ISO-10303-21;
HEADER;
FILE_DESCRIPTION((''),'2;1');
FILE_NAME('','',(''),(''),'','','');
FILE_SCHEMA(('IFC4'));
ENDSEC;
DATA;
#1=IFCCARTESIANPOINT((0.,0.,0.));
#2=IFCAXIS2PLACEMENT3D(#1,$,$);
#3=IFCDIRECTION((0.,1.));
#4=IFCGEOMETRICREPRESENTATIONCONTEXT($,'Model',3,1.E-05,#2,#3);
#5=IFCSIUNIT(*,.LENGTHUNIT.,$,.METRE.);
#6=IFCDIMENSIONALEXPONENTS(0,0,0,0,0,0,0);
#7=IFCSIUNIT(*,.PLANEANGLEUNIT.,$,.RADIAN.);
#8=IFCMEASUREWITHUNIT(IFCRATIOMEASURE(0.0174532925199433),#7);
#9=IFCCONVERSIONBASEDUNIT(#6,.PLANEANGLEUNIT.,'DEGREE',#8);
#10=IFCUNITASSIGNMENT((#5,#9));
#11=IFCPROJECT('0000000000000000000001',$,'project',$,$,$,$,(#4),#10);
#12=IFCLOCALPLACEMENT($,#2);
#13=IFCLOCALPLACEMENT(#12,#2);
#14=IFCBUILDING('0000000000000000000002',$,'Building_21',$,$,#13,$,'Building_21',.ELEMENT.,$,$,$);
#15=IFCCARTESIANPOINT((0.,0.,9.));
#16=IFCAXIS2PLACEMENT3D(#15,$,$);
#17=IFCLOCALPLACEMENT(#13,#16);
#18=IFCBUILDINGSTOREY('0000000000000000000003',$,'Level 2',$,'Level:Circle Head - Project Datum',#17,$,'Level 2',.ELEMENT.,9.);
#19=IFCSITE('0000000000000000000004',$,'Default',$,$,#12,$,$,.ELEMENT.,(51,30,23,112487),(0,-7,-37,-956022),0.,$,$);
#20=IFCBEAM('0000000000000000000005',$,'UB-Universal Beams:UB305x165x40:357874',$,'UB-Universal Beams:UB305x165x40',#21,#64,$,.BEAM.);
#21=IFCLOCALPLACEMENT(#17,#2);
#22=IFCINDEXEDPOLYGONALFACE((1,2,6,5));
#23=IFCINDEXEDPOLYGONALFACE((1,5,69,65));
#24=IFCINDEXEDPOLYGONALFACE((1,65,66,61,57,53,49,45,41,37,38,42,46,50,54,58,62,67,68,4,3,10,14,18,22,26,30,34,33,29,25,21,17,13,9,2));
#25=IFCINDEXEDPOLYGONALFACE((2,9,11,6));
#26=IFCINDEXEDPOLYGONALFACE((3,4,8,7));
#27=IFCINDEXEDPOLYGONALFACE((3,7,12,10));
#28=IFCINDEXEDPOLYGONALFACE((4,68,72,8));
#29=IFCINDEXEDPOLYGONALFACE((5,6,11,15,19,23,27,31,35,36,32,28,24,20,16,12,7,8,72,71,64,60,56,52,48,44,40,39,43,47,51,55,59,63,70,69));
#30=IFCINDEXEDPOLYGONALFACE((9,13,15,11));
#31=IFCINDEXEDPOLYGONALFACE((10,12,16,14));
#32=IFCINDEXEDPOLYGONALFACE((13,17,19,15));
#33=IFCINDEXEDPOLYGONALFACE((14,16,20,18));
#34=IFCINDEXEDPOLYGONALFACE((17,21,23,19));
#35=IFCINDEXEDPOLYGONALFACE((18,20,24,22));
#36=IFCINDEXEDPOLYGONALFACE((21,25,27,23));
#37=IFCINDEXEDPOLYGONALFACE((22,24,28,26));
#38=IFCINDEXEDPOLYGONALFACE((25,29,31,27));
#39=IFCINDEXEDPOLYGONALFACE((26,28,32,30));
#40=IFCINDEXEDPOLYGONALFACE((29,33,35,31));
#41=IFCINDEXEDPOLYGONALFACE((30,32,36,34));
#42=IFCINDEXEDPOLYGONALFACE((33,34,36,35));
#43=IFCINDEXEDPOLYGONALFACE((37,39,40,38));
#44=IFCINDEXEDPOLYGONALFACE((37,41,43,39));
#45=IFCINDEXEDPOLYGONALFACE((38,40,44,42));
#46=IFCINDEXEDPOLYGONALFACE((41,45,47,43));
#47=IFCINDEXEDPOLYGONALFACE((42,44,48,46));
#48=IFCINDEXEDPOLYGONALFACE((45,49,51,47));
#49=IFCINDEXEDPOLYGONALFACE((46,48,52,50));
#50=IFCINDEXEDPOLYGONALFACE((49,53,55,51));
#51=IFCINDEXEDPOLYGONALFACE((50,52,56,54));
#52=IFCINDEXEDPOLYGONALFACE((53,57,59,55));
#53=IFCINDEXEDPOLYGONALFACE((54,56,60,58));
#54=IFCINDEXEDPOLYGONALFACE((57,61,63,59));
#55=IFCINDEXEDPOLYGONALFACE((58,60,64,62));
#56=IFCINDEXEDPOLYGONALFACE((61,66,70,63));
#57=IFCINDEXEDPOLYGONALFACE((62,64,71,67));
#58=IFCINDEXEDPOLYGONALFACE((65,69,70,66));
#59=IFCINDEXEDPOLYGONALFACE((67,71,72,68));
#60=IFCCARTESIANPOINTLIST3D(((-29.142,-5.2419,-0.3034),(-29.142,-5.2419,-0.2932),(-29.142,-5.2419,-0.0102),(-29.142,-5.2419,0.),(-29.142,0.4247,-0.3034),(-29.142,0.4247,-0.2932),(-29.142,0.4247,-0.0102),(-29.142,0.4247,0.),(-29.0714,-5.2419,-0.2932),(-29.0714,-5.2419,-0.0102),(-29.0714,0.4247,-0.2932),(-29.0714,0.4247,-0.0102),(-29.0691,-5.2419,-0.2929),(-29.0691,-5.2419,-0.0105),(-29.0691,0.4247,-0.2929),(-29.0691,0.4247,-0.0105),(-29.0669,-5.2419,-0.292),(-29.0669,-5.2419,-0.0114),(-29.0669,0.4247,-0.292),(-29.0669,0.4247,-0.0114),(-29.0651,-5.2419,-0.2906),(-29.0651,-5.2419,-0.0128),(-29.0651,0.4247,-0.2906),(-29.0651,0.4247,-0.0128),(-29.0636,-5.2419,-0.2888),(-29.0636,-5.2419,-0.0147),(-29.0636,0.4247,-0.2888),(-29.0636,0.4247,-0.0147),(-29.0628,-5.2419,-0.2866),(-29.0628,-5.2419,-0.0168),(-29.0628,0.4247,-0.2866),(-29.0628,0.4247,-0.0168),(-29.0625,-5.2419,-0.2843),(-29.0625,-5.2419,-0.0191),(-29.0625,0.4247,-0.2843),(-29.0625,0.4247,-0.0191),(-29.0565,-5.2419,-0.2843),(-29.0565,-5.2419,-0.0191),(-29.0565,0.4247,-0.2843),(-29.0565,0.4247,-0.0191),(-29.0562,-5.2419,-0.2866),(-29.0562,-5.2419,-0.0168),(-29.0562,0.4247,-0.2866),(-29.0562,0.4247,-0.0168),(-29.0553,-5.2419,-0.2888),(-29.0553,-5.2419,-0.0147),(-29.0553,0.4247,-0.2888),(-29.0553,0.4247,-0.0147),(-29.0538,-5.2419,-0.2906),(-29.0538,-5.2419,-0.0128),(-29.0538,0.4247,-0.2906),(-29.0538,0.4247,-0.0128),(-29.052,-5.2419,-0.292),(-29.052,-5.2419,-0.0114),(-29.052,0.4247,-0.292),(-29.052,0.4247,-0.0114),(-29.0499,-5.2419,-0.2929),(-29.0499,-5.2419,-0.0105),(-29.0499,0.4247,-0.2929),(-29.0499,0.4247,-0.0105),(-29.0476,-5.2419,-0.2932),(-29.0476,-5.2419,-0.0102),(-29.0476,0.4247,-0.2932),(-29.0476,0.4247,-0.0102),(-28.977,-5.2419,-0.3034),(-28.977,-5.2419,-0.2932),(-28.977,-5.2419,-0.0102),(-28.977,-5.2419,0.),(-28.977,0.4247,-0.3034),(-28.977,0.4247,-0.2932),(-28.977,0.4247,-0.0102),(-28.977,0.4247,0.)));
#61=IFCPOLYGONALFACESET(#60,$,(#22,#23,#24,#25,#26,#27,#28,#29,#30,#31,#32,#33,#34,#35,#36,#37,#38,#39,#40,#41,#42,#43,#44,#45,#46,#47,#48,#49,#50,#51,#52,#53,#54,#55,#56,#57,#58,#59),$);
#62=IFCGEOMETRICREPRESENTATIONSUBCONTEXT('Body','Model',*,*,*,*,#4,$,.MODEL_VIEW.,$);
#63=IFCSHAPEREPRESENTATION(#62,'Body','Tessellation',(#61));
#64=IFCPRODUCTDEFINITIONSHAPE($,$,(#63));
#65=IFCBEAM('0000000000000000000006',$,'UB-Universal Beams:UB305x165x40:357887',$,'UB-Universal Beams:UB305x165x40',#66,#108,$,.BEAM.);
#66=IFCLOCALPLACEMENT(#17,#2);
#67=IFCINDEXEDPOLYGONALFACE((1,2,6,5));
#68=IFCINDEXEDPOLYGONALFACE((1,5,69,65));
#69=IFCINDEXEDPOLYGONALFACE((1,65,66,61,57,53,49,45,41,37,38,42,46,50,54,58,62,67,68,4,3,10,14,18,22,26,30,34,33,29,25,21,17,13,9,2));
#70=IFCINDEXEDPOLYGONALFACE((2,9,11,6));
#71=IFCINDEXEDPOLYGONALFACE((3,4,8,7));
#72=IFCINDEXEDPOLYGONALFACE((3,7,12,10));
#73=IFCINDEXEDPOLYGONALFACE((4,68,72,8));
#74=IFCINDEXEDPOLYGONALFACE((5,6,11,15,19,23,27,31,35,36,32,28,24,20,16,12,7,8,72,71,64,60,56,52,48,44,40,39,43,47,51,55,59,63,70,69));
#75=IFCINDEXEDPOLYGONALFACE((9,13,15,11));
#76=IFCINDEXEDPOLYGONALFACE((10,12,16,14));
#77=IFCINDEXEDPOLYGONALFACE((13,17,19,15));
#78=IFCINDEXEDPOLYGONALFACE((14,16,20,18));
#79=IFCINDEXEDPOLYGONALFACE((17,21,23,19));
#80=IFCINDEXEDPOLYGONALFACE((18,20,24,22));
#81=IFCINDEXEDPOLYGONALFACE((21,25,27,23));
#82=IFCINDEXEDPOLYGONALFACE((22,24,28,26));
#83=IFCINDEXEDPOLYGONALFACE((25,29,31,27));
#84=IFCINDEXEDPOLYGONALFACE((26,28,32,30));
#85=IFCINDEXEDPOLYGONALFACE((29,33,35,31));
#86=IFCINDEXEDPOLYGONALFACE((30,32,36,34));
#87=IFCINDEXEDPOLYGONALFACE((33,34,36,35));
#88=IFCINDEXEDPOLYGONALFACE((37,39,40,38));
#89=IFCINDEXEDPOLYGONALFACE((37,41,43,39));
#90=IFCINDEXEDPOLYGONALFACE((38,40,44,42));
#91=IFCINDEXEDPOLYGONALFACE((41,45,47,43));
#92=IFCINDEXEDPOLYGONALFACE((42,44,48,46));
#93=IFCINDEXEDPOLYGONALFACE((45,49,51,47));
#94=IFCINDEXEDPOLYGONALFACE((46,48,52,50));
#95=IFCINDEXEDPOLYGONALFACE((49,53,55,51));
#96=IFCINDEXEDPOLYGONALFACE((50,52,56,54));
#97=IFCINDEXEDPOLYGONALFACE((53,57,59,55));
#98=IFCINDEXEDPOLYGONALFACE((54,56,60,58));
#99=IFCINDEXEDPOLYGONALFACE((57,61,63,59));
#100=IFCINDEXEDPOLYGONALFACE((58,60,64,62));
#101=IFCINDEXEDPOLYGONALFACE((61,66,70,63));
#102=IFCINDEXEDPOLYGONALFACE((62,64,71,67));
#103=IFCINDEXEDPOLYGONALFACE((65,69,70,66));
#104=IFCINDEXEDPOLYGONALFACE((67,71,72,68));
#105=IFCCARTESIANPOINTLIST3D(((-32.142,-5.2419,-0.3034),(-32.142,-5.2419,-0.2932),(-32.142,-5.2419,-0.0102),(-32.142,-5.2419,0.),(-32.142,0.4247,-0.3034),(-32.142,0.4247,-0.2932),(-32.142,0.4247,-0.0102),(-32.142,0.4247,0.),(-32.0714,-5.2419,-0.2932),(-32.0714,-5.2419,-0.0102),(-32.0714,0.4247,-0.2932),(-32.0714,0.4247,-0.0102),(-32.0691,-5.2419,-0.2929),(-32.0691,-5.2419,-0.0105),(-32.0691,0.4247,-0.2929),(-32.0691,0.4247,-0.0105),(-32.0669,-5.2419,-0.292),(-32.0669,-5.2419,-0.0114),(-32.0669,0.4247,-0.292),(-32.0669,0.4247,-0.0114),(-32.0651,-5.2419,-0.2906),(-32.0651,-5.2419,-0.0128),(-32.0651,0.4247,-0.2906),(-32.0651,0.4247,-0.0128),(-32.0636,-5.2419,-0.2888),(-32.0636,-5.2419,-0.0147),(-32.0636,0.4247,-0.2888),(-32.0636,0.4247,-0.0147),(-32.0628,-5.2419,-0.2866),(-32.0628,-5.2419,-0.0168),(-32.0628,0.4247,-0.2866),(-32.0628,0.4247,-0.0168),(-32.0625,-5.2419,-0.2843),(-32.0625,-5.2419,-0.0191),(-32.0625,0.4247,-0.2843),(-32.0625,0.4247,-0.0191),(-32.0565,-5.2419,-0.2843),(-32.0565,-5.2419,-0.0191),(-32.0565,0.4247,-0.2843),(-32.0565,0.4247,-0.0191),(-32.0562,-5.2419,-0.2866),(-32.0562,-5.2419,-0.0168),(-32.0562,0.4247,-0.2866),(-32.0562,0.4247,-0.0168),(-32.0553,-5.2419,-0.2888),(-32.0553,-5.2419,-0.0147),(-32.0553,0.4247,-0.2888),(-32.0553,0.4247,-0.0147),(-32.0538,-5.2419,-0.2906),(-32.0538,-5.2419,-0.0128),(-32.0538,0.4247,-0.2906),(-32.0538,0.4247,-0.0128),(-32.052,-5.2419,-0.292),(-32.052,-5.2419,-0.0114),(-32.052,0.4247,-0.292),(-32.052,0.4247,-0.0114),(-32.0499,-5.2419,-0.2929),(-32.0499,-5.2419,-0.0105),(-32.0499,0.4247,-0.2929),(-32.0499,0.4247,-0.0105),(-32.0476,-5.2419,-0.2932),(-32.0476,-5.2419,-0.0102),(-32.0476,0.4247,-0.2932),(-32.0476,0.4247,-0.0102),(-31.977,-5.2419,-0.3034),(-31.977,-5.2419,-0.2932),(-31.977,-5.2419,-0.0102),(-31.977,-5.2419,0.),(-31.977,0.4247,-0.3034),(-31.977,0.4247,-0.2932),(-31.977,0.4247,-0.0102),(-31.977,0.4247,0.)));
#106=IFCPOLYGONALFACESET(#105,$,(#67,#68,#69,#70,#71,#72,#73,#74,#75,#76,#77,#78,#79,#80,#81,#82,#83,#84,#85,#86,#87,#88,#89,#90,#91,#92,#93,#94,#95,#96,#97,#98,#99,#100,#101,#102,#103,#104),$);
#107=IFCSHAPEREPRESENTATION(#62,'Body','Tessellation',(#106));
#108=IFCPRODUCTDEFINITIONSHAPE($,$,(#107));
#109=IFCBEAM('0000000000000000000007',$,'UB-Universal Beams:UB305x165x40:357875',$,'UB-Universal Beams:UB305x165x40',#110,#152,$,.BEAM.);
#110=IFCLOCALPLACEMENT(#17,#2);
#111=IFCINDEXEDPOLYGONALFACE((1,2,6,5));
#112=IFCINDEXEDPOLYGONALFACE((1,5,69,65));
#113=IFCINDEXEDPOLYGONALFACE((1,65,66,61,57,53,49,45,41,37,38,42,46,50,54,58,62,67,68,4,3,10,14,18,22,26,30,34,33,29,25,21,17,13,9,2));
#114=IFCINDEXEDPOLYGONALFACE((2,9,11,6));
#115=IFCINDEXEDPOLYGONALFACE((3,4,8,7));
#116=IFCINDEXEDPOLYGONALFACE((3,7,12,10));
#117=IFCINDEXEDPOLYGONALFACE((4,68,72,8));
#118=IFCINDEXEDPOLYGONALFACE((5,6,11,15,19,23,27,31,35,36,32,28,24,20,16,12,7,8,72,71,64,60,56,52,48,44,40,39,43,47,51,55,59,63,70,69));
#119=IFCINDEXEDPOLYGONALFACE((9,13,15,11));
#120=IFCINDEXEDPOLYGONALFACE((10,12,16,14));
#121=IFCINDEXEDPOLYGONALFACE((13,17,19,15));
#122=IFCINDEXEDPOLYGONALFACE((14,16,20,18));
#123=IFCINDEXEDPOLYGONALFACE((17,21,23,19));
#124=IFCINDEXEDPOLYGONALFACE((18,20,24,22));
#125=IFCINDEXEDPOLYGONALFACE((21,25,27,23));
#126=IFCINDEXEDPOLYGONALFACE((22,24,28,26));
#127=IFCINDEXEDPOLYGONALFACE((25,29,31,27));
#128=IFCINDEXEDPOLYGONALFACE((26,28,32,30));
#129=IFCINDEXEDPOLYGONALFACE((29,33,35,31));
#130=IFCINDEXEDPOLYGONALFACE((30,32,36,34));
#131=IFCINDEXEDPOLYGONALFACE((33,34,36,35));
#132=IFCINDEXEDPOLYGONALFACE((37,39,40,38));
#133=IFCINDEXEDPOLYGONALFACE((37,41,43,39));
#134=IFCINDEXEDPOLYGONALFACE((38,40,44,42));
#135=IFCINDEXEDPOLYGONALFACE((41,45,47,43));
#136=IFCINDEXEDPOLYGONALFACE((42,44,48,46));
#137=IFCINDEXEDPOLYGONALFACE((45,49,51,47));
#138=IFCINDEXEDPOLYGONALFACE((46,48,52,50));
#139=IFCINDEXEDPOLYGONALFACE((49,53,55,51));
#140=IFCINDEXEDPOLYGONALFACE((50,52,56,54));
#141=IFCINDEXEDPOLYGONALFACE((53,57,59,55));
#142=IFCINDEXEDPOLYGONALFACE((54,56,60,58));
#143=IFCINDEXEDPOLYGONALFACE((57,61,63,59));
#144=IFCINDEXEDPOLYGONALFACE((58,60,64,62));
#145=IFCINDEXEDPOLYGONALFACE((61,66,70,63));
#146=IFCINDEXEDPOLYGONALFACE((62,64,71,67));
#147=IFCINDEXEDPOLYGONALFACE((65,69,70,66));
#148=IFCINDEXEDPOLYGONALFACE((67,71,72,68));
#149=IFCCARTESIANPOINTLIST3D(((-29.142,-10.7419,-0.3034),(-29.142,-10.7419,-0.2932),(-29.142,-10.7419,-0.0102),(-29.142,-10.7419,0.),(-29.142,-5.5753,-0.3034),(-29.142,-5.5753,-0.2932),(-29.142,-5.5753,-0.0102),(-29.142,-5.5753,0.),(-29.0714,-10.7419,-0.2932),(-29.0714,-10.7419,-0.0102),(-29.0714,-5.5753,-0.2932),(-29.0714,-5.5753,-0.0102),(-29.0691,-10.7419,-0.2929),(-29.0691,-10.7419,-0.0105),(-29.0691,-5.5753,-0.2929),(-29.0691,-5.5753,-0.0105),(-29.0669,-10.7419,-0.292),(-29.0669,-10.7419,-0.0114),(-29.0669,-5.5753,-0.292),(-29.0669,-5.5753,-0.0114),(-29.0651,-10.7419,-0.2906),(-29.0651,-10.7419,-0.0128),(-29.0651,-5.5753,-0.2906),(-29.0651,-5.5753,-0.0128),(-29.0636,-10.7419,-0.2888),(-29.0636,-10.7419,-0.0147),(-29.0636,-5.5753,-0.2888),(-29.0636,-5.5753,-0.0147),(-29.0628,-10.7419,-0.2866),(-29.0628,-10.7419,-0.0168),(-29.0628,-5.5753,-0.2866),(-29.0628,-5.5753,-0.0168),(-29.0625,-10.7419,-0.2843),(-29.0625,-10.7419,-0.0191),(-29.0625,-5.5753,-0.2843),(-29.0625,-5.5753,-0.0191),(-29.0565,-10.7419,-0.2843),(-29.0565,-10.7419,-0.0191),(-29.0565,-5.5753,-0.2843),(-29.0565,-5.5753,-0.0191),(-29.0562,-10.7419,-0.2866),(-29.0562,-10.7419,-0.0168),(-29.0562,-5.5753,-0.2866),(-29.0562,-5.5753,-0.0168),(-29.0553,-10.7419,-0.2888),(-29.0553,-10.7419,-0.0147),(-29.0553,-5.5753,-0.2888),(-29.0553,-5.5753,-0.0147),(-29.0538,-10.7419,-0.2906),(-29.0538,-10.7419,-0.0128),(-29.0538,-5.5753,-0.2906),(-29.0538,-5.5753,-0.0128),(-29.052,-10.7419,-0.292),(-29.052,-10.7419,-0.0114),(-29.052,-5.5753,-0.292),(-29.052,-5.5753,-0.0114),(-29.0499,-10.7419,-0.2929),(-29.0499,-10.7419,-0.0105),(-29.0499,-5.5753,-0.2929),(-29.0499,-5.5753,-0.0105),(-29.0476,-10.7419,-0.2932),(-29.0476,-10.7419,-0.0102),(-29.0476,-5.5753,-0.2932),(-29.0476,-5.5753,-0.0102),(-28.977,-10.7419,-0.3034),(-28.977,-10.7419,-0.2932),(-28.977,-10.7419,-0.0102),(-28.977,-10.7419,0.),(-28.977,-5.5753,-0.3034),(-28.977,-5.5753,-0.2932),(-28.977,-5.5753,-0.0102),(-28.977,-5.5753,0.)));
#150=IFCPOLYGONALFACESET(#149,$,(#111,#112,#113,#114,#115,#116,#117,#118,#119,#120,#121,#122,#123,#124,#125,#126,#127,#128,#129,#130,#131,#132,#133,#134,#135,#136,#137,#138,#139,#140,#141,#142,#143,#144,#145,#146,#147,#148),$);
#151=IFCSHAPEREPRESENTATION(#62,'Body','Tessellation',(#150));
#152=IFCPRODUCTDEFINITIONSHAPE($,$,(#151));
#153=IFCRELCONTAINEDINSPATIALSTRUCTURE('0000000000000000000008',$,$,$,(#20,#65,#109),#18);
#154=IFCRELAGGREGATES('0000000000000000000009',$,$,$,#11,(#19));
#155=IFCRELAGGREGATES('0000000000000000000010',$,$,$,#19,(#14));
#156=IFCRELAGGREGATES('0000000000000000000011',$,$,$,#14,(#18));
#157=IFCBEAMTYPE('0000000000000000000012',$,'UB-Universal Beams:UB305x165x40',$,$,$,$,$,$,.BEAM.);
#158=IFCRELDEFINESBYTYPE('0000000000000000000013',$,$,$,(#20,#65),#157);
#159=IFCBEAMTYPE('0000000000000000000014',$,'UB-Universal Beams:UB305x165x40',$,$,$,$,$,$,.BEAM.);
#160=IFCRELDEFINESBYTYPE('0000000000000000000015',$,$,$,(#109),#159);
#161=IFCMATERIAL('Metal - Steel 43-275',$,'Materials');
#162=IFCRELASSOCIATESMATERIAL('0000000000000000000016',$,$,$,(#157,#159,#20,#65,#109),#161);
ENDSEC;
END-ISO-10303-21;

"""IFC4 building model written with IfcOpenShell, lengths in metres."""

from ifc_helpers import new_model, entity, si_unit, converted_unit, direction, frame, frame_2d, origin, place, context, subcontext, project, spatial, polyline, circle_curve, parameter, trimmed, segment, composite_curve, i_section, outline, extrude, source, transform, mapped, material, material_profile, profile_set, profile_usage, type_object, type_shapes, element, save


model = new_model("IFC4")

# Units and contexts
model_context = context("Model", 3, precision=1e-05, world=origin(), true_north=direction((0.0, 1.0)))
body_context = subcontext(model_context, "Body", "Model", "MODEL_VIEW")
ifc_project = project(units=[si_unit("LENGTHUNIT", "METRE"), converted_unit("PLANEANGLEUNIT", "DEGREE", entity("IfcRatioMeasure", 0.0174532925199433), si_unit("PLANEANGLEUNIT", "RADIAN"), dimensions=[0, 0, 0, 0, 0, 0, 0])], contexts=[model_context])

# Site, building, storey
site_placement = place(None, origin())
site = spatial("IfcSite", under=ifc_project, at=site_placement, Name="Default", CompositionType="ELEMENT", RefLatitude=(51, 30, 23, 112487), RefLongitude=(0, -7, -37, -956022), RefElevation=0.0)
building_placement = place(site_placement, origin())
building = spatial("IfcBuilding", under=site, at=building_placement, Name="Building_21", LongName="Building_21", CompositionType="ELEMENT")
storey_placement = place(building_placement, frame((0.0, 0.0, 9.0)))
storey = spatial("IfcBuildingStorey", under=building, at=storey_placement, Name="Level 2", ObjectType="Level:Circle Head - Project Datum", LongName="Level 2", CompositionType="ELEMENT", Elevation=9.0)

# Shared definitions
ifc_material_1 = material(Name="Metal - Steel 43-275", Category="Materials")

# Beams
ifc_material_profile_1 = material_profile(ifc_material_1, outline(composite_curve([segment(polyline([(0.0119, -0.1415, 0.0), (0.0825, -0.1415, 0.0)]), True, "CONTINUOUS"), segment(polyline([(0.0825, -0.1415, 0.0), (0.0825, -0.1517, 0.0)]), True, "CONTINUOUS"), segment(polyline([(0.0825, -0.1517, 0.0), (-0.0825, -0.1517, 0.0)]), True, "CONTINUOUS"), segment(polyline([(-0.0825, -0.1517, 0.0), (-0.0825, -0.1415, 0.0)]), True, "CONTINUOUS"), segment(polyline([(-0.0825, -0.1415, 0.0), (-0.0119, -0.1415, 0.0)]), True, "CONTINUOUS"), segment(trimmed(circle_curve(frame((-0.0119, -0.1326, 0.0), z_axis=(0.0, 0.0, 1.0), x_axis=(-1.0, 0.0, 0.0)), 0.0089), [parameter(90.0)], [parameter(180.0)], True, "PARAMETER"), True, "CONTINUOUS"), segment(polyline([(-0.003, -0.1326, 0.0), (-0.003, 0.1326, 0.0)]), True, "CONTINUOUS"), segment(trimmed(circle_curve(frame((-0.0119, 0.1326, 0.0), z_axis=(0.0, 0.0, 1.0), x_axis=(-1.0, 0.0, 0.0)), 0.0089), [parameter(180.0)], [parameter(270.0)], True, "PARAMETER"), True, "CONTINUOUS"), segment(polyline([(-0.0119, 0.1415, 0.0), (-0.0825, 0.1415, 0.0)]), True, "CONTINUOUS"), segment(polyline([(-0.0825, 0.1415, 0.0), (-0.0825, 0.1517, 0.0)]), True, "CONTINUOUS"), segment(polyline([(-0.0825, 0.1517, 0.0), (0.0825, 0.1517, 0.0)]), True, "CONTINUOUS"), segment(polyline([(0.0825, 0.1517, 0.0), (0.0825, 0.1415, 0.0)]), True, "CONTINUOUS"), segment(polyline([(0.0825, 0.1415, 0.0), (0.0119, 0.1415, 0.0)]), True, "CONTINUOUS"), segment(trimmed(circle_curve(frame((0.0119, 0.1326, 0.0), z_axis=(0.0, 0.0, 1.0), x_axis=(-1.0, 0.0, 0.0)), 0.0089), [parameter(270.0)], [parameter(0.0)], True, "PARAMETER"), True, "CONTINUOUS"), segment(polyline([(0.003, 0.1326, 0.0), (0.003, -0.1326, 0.0)]), True, "CONTINUOUS"), segment(trimmed(circle_curve(frame((0.0119, -0.1326, 0.0), z_axis=(0.0, 0.0, 1.0), x_axis=(-1.0, 0.0, 0.0)), 0.0089), [parameter(0.0)], [parameter(90.0)], True, "PARAMETER"), True, "CONTINUOUS")], self_intersect=False), kind="CURVE"), Name="UB305x165x40")
ifc_material_profile_2 = material_profile(ifc_material_1, outline(composite_curve([segment(polyline([(-1.3346, 0.0825, -0.1415), (-1.3346, 0.0825, -0.1517)]), True, "CONTINUOUS"), segment(polyline([(-1.3346, 0.0825, -0.1517), (-1.3346, -0.0825, -0.1517)]), True, "CONTINUOUS"), segment(polyline([(-1.3346, -0.0825, -0.1517), (-1.3346, -0.0825, -0.1415)]), True, "CONTINUOUS"), segment(polyline([(-1.3346, -0.0825, -0.1415), (-1.3346, -0.003, -0.1415)]), True, "CONTINUOUS"), segment(polyline([(-1.3346, -0.003, -0.1415), (-1.3346, -0.003, 0.1415)]), True, "CONTINUOUS"), segment(polyline([(-1.3346, -0.003, 0.1415), (-1.3346, -0.0825, 0.1415)]), True, "CONTINUOUS"), segment(polyline([(-1.3346, -0.0825, 0.1415), (-1.3346, -0.0825, 0.1517)]), True, "CONTINUOUS"), segment(polyline([(-1.3346, -0.0825, 0.1517), (-1.3346, 0.0825, 0.1517)]), True, "CONTINUOUS"), segment(polyline([(-1.3346, 0.0825, 0.1517), (-1.3346, 0.0825, 0.1415)]), True, "CONTINUOUS"), segment(polyline([(-1.3346, 0.0825, 0.1415), (-1.3346, 0.003, 0.1415)]), True, "CONTINUOUS"), segment(polyline([(-1.3346, 0.003, 0.1415), (-1.3346, 0.003, -0.1415)]), True, "CONTINUOUS"), segment(polyline([(-1.3346, 0.003, -0.1415), (-1.3346, 0.0825, -0.1415)]), True, "CONTINUOUS")], self_intersect=False), kind="CURVE"), Name="UB305x165x40")
ifc_profile_set_1 = profile_set([ifc_material_profile_1, ifc_material_profile_2], Name="UB305x165x40")
ifc_profile_usage_1 = profile_usage(ifc_profile_set_1, cardinal=8)
beam_type_1 = type_object("IfcBeamType", Name="UB-Universal Beams:UB305x165x40", PredefinedType="BEAM", material=ifc_profile_set_1)
shared_shape_1 = source(origin(), body_context, "Body", "SweptSolid", [
    extrude(i_section(OverallWidth=0.165, OverallDepth=0.3034, WebThickness=0.006, FlangeThickness=0.0102, FilletRadius=0.0089, at=frame_2d((0.0, 0.0), x_axis=(0.0, 1.0))), frame((-2.8333, 0.0, 0.0), z_axis=(1.0, 0.0, 0.0), x_axis=(0.0, 0.0, -1.0)), (0.0, 0.0, 1.0), 5.6666),
])
type_shapes(beam_type_1, [shared_shape_1])
beam_1_placement = place(storey_placement, frame((-29.0595, -2.4086, -0.1517), z_axis=(0.0, 0.0, 1.0), x_axis=(0.0, 1.0, 0.0)))
element("IfcBeam", 1, at=beam_1_placement, inside=storey, type_object=beam_type_1, material=ifc_profile_usage_1, Name="UB-Universal Beams:UB305x165x40:357874", ObjectType="UB-Universal Beams:UB305x165x40", PredefinedType="BEAM", context=body_context, shape_type="MappedRepresentation", body=[
    mapped(shared_shape_1, transform((0.0, 0.0, 0.0), scale=1.0)),
])
ifc_profile_usage_2 = profile_usage(ifc_profile_set_1, cardinal=8)
beam_2_placement = place(storey_placement, frame((-32.0595, -2.4086, -0.1517), z_axis=(0.0, 0.0, 1.0), x_axis=(0.0, -1.0, 0.0)))
element("IfcBeam", 2, at=beam_2_placement, inside=storey, type_object=beam_type_1, material=ifc_profile_usage_2, Name="UB-Universal Beams:UB305x165x40:357887", ObjectType="UB-Universal Beams:UB305x165x40", PredefinedType="BEAM", context=body_context, shape_type="MappedRepresentation", body=[
    mapped(shared_shape_1, transform((0.0, 0.0, 0.0), scale=1.0)),
])
ifc_profile_usage_3 = profile_usage(ifc_profile_set_1, cardinal=8)
beam_type_2 = type_object("IfcBeamType", Name="UB-Universal Beams:UB305x165x40", PredefinedType="BEAM", material=ifc_profile_set_1)
shared_shape_2 = source(origin(), body_context, "Body", "SweptSolid", [
    extrude(i_section(OverallWidth=0.165, OverallDepth=0.3034, WebThickness=0.006, FlangeThickness=0.0102, FilletRadius=0.0089, at=frame_2d((0.0, 0.0), x_axis=(0.0, 1.0))), frame((-2.5833, 0.0, 0.0), z_axis=(1.0, 0.0, 0.0), x_axis=(0.0, 0.0, -1.0)), (0.0, 0.0, 1.0), 5.1666),
])
type_shapes(beam_type_2, [shared_shape_2])
beam_3_placement = place(storey_placement, frame((-29.0595, -8.1586, -0.1517), z_axis=(0.0, 0.0, 1.0), x_axis=(0.0, 1.0, 0.0)))
element("IfcBeam", 3, at=beam_3_placement, inside=storey, type_object=beam_type_2, material=ifc_profile_usage_3, Name="UB-Universal Beams:UB305x165x40:357875", ObjectType="UB-Universal Beams:UB305x165x40", PredefinedType="BEAM", context=body_context, shape_type="MappedRepresentation", body=[
    mapped(shared_shape_2, transform((0.0, 0.0, 0.0), scale=1.0)),
])

save(model, "model.ifc")
